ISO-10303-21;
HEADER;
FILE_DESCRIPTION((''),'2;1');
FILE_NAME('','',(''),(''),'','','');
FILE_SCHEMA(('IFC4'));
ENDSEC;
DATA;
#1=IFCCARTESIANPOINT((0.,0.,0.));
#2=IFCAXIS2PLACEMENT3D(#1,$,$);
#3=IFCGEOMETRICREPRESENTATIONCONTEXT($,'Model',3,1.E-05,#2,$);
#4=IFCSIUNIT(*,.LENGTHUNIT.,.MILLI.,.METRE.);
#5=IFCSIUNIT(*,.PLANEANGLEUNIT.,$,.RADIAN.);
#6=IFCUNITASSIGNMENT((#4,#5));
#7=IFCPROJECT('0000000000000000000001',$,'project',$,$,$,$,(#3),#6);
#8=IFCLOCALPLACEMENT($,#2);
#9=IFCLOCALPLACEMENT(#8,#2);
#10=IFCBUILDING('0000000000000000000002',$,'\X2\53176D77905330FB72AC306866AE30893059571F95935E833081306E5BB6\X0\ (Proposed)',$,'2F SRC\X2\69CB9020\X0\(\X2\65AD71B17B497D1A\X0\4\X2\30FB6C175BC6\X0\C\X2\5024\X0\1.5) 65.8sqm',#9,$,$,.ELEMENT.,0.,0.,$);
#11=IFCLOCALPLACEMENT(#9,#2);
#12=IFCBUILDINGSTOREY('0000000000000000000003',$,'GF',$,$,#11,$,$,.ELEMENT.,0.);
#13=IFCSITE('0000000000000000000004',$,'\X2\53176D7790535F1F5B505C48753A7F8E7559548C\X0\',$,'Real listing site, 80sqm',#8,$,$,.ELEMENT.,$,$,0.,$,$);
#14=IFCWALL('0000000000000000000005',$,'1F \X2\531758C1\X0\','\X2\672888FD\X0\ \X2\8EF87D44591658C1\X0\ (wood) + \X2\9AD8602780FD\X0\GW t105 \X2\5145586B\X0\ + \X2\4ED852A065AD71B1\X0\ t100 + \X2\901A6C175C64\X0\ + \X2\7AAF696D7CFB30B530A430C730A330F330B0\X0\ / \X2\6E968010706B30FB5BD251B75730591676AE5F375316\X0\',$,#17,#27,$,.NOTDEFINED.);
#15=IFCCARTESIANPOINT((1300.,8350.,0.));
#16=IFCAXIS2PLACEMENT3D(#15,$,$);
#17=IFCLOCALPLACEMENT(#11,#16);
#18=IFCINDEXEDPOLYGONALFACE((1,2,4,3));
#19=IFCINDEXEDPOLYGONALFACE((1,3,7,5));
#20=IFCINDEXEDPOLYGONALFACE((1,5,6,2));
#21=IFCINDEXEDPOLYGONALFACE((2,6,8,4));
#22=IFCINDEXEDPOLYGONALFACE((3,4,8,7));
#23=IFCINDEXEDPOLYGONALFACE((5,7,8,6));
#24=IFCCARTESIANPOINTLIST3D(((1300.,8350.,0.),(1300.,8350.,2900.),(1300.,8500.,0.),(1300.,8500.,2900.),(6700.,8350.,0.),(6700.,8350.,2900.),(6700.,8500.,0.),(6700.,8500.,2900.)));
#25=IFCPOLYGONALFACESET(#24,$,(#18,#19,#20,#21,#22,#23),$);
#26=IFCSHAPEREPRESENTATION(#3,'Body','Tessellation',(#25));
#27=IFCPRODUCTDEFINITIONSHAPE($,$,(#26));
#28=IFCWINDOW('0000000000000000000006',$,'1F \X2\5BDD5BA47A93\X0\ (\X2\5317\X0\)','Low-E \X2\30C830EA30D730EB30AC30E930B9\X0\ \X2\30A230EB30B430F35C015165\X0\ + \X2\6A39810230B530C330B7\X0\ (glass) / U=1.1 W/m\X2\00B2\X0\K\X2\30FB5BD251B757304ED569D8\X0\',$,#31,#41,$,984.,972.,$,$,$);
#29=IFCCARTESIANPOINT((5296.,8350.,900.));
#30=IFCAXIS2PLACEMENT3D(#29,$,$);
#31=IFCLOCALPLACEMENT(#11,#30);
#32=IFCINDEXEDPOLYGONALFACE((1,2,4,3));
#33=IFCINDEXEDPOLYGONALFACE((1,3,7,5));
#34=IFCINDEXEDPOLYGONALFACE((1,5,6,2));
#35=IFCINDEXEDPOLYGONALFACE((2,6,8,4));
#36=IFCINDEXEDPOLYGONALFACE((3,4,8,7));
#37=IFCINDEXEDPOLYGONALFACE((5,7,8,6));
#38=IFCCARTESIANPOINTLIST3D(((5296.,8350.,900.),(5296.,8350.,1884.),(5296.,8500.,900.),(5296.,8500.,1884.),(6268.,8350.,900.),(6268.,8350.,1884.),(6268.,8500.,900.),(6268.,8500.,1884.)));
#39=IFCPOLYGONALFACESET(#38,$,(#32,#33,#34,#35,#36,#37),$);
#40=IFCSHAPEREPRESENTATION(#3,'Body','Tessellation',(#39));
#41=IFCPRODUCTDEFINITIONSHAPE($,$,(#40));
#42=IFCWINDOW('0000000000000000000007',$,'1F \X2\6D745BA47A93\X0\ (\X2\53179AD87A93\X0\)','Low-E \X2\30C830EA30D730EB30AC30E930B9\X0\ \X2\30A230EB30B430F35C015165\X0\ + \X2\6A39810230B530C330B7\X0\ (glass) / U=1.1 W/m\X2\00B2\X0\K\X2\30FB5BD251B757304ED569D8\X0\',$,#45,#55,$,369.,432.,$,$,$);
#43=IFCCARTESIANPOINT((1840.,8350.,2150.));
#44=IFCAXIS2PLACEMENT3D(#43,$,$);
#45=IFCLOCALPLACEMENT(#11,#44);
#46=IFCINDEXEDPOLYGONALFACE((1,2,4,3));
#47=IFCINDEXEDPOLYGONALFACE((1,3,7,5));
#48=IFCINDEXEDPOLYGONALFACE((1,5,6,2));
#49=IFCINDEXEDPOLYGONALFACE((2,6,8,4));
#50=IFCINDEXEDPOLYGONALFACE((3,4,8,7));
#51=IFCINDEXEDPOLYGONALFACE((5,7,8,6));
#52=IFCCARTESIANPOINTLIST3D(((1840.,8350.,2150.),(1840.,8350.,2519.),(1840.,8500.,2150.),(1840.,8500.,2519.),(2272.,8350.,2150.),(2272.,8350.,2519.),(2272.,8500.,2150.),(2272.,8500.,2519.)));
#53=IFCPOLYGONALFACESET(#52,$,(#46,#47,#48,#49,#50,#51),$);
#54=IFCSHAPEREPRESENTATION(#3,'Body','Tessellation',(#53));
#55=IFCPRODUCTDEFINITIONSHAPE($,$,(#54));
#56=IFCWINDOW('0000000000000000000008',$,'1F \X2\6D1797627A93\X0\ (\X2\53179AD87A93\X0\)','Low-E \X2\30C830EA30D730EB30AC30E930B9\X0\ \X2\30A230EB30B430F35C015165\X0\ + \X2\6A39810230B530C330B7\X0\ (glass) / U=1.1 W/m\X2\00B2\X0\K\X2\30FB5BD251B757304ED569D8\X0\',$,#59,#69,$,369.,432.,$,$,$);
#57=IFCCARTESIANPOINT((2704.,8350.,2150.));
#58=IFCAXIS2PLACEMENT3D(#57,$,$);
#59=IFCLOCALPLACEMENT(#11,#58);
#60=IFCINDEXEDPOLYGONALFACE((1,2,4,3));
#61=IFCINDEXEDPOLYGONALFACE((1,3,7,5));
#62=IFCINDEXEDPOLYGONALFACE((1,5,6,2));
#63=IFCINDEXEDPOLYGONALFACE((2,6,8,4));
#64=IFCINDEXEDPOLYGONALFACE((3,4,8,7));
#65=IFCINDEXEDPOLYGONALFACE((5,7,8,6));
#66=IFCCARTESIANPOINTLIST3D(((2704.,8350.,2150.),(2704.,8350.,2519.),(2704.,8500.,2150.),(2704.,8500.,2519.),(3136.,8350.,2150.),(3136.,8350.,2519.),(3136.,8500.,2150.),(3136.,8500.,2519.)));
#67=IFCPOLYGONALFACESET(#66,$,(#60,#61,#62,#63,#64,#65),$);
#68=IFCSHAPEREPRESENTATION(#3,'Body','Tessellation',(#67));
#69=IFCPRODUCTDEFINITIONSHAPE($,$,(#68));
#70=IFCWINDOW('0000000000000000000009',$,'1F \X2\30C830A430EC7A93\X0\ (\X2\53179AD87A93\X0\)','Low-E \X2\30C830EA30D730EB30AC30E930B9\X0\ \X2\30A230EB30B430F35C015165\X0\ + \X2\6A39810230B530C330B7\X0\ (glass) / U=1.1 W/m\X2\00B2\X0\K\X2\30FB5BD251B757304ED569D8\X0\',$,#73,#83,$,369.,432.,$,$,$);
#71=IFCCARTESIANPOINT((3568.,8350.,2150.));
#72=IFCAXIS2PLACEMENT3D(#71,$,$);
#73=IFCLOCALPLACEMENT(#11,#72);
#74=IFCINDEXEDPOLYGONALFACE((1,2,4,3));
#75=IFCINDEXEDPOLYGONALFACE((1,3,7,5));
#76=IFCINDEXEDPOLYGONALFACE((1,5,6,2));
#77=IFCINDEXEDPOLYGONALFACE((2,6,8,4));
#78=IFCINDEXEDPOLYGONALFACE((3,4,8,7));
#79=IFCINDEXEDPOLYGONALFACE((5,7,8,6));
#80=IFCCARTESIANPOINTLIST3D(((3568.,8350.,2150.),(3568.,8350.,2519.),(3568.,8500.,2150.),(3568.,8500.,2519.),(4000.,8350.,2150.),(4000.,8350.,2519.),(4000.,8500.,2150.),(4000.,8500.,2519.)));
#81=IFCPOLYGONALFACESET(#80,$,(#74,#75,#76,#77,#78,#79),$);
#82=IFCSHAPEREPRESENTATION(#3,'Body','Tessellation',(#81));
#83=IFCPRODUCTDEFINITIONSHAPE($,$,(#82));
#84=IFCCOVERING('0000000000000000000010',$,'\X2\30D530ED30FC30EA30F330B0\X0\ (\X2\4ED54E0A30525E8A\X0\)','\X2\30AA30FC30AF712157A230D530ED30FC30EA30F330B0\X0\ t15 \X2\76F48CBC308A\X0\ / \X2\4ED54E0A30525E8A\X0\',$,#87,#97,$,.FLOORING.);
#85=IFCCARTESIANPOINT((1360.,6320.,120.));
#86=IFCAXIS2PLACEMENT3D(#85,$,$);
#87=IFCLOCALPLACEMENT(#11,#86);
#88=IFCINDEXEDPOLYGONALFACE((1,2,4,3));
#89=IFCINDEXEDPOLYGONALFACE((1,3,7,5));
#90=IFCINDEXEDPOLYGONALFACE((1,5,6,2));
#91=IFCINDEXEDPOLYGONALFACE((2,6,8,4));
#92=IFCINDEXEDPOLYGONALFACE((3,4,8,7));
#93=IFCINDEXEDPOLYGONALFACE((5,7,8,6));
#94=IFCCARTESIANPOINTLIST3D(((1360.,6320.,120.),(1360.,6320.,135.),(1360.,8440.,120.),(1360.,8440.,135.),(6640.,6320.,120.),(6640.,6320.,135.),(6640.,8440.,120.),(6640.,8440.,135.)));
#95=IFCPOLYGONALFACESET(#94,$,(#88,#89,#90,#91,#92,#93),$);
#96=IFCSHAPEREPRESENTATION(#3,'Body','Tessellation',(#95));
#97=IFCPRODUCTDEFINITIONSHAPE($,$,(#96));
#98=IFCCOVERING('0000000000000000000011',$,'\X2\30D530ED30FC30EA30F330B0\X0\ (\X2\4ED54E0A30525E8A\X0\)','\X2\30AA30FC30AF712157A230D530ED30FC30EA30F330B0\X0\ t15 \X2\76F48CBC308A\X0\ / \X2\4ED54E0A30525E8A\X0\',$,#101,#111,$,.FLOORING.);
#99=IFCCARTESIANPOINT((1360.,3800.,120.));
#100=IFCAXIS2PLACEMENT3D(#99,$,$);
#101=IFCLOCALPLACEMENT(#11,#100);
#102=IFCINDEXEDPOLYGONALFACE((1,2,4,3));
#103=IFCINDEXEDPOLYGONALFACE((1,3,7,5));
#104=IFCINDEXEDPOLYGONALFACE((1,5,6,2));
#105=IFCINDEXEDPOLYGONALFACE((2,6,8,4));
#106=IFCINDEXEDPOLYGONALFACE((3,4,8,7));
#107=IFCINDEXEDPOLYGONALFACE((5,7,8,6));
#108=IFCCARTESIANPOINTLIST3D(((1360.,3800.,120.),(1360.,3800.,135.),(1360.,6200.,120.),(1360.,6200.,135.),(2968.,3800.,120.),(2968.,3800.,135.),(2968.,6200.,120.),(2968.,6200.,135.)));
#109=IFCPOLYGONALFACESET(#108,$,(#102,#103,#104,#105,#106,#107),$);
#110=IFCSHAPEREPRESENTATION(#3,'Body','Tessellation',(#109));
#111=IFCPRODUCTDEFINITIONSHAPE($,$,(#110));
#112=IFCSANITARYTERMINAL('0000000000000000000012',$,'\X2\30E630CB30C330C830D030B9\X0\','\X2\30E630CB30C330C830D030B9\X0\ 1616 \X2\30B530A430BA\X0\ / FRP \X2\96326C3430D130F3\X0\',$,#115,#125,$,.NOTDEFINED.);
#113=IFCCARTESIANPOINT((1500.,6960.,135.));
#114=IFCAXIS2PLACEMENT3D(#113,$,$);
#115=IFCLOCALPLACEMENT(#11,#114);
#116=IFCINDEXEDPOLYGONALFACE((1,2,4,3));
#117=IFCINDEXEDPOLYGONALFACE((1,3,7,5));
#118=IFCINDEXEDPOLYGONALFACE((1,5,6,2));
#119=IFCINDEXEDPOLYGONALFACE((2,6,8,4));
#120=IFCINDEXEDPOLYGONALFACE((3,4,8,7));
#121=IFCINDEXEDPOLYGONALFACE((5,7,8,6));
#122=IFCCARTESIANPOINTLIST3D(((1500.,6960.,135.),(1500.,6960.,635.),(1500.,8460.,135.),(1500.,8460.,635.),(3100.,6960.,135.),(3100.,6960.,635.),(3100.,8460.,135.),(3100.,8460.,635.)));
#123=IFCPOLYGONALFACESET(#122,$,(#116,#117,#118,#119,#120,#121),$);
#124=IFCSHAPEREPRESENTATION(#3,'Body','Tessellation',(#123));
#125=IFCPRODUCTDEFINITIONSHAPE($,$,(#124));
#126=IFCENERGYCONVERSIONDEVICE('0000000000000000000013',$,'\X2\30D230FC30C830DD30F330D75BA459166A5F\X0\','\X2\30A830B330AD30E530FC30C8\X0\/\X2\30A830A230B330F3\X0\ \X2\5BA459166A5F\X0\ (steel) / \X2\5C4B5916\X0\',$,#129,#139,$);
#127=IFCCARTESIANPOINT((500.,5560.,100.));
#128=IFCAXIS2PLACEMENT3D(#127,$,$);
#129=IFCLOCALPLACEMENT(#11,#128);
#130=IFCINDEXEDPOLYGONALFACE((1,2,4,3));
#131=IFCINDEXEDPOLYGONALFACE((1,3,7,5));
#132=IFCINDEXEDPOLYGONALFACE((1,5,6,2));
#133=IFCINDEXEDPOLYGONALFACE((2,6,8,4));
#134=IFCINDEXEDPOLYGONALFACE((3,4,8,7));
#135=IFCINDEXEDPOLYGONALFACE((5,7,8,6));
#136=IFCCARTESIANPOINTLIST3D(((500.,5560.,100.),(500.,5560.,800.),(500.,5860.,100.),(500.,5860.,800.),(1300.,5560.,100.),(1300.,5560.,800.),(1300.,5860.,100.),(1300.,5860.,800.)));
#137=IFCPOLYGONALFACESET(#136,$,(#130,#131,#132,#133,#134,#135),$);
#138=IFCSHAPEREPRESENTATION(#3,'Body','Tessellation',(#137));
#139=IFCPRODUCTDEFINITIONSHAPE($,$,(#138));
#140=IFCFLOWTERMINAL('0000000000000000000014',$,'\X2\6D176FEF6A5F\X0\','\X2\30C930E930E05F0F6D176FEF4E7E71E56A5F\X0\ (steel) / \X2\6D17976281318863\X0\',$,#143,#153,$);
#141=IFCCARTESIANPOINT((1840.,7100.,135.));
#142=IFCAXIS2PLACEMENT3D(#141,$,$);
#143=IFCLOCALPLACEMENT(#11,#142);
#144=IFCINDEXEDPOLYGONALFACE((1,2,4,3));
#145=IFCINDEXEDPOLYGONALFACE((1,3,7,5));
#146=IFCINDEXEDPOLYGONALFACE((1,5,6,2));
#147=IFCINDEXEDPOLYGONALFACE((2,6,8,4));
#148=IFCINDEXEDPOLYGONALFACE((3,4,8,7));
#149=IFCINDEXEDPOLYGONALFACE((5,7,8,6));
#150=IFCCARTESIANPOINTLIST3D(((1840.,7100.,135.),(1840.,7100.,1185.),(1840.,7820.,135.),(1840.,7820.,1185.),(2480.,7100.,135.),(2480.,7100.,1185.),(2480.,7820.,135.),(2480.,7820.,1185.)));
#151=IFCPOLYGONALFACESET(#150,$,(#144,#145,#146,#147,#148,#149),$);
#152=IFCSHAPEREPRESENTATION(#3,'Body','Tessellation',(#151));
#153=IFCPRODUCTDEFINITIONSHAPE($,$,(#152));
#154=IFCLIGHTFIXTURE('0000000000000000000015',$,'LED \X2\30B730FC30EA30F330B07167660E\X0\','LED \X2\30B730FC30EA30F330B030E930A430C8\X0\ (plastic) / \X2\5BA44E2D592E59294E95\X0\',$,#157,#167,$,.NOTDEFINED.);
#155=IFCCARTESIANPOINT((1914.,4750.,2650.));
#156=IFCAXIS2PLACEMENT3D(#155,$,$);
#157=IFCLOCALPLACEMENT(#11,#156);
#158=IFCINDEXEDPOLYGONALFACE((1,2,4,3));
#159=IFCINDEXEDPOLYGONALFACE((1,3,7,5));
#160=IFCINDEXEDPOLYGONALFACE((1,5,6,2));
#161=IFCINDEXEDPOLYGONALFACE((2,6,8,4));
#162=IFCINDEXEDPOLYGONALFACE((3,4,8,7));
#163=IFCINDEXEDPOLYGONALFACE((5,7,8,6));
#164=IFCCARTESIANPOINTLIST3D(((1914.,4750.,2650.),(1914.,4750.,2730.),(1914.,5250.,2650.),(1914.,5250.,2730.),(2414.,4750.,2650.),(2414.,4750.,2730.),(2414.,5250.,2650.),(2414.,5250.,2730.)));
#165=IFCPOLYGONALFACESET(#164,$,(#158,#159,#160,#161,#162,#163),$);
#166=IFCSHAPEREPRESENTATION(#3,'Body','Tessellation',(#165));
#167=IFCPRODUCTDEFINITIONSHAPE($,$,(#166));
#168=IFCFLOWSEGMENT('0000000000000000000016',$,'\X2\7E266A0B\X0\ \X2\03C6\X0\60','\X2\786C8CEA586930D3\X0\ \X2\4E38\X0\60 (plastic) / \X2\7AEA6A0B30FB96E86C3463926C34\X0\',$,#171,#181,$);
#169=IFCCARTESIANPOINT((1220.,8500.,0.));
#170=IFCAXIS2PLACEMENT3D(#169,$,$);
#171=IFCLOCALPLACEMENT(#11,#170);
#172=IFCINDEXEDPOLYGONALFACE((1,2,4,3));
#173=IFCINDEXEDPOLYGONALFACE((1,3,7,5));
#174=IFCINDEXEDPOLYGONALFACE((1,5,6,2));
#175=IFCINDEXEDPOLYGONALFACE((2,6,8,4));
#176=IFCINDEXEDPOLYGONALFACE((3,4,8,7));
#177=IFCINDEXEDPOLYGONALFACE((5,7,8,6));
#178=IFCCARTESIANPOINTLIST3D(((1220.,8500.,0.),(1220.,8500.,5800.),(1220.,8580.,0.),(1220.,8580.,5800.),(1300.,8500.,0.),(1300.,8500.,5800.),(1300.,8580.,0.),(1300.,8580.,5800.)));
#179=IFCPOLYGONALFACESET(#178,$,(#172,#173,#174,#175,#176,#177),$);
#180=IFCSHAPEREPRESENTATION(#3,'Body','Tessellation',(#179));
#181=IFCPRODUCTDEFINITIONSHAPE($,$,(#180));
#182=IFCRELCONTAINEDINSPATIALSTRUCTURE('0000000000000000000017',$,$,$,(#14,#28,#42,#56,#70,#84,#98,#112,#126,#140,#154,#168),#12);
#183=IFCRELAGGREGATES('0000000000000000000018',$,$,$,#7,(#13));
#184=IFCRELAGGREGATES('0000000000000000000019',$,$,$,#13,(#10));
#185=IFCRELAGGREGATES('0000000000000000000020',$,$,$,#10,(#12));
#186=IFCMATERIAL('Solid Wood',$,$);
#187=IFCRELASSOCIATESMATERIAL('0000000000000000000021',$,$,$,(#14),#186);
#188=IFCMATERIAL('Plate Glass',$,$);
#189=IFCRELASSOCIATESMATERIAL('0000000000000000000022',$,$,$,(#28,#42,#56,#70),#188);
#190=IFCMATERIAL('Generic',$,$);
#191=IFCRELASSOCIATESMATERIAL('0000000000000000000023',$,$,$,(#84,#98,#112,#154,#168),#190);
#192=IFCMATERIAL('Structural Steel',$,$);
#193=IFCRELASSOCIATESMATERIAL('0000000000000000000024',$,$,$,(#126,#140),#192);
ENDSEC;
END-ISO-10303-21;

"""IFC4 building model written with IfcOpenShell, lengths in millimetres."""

from ifc_helpers import new_model, si_unit, frame, frame_2d, origin, place, context, project, spatial, rectangle, extrude, material, element, fill, save


model = new_model("IFC4")

# Units and contexts
model_context = context("Model", 3, precision=1e-05, world=origin())
ifc_project = project(units=[si_unit("LENGTHUNIT", "METRE", prefix="MILLI"), si_unit("PLANEANGLEUNIT", "RADIAN")], contexts=[model_context])

# Site, building, storey
site_placement = place(None, origin())
site = spatial("IfcSite", under=ifc_project, at=site_placement, Name="北海道弟子屈町美留和", ObjectType="Real listing site, 80sqm", CompositionType="ELEMENT", RefElevation=0.0)
building_placement = place(site_placement, origin())
building = spatial("IfcBuilding", under=site, at=building_placement, Name="北海道・犬と暮らす土間広めの家 (Proposed)", ObjectType="2F SRC構造(断熱等級4・気密C値1.5) 65.8sqm", CompositionType="ELEMENT", ElevationOfRefHeight=0.0, ElevationOfTerrain=0.0)
storey_placement = place(building_placement, origin())
storey = spatial("IfcBuildingStorey", under=building, at=storey_placement, Name="GF", CompositionType="ELEMENT", Elevation=0.0)

# Shared definitions
ifc_material_1 = material(Name="Solid Wood")

# Wall, openings, windows
wall_1_placement = place(storey_placement, frame((1300.0, 8350.0, 0.0)))
wall_1 = element("IfcWall", 1, at=wall_1_placement, inside=storey, material=ifc_material_1, Name="1F 北壁", Description="木製 軸組外壁 (wood) + 高性能GW t105 充填 + 付加断熱 t100 + 通気層 + 窯業系サイディング / 準耐火・寒冷地外皮強化", PredefinedType="NOTDEFINED", context=model_context, shape_type="SweptSolid", body=[
    extrude(rectangle(XDim=5400.0, YDim=150.0, at=frame_2d((2700.0, 75.0))), frame((1300.0, 8350.0, 0.0)), (0.0, 0.0, 1.0), 2900.0),
])
opening_1_placement = place(storey_placement, frame((5296.0, 8350.0, 900.0)))
opening_1 = element("IfcOpeningElement", 2, at=opening_1_placement, cuts=wall_1, PredefinedType="NOTDEFINED", context=model_context, shape_type="SweptSolid", body=[
    extrude(rectangle(XDim=972.0, YDim=150.0, at=frame_2d((486.0, 75.0))), frame((5296.0, 8350.0, 900.0)), (0.0, 0.0, 1.0), 984.0),
])
opening_2_placement = place(storey_placement, frame((1840.0, 8350.0, 2150.0)))
opening_2 = element("IfcOpeningElement", 3, at=opening_2_placement, cuts=wall_1, PredefinedType="NOTDEFINED", context=model_context, shape_type="SweptSolid", body=[
    extrude(rectangle(XDim=432.0, YDim=150.0, at=frame_2d((216.0, 75.0))), frame((1840.0, 8350.0, 2150.0)), (0.0, 0.0, 1.0), 369.0),
])
opening_3_placement = place(storey_placement, frame((2704.0, 8350.0, 2150.0)))
opening_3 = element("IfcOpeningElement", 4, at=opening_3_placement, cuts=wall_1, PredefinedType="NOTDEFINED", context=model_context, shape_type="SweptSolid", body=[
    extrude(rectangle(XDim=432.0, YDim=150.0, at=frame_2d((216.0, 75.0))), frame((2704.0, 8350.0, 2150.0)), (0.0, 0.0, 1.0), 369.0),
])
opening_4_placement = place(storey_placement, frame((3568.0, 8350.0, 2150.0)))
opening_4 = element("IfcOpeningElement", 5, at=opening_4_placement, cuts=wall_1, PredefinedType="NOTDEFINED", context=model_context, shape_type="SweptSolid", body=[
    extrude(rectangle(XDim=432.0, YDim=150.0, at=frame_2d((216.0, 75.0))), frame((3568.0, 8350.0, 2150.0)), (0.0, 0.0, 1.0), 369.0),
])
ifc_material_2 = material(Name="Plate Glass")
window_1_placement = place(storey_placement, frame((5296.0, 8350.0, 900.0)))
window_1 = element("IfcWindow", 6, at=window_1_placement, inside=storey, material=ifc_material_2, Name="1F 寝室窓 (北)", Description="Low-E トリプルガラス アルゴン封入 + 樹脂サッシ (glass) / U=1.1 W/m²K・寒冷地仕様", OverallHeight=984.0, OverallWidth=972.0, context=model_context, shape_type="SweptSolid", body=[
    extrude(rectangle(XDim=972.0, YDim=150.0, at=frame_2d((486.0, 75.0))), frame((5296.0, 8350.0, 900.0)), (0.0, 0.0, 1.0), 984.0),
])
fill(opening_1, window_1)
window_2_placement = place(storey_placement, frame((1840.0, 8350.0, 2150.0)))
window_2 = element("IfcWindow", 7, at=window_2_placement, inside=storey, material=ifc_material_2, Name="1F 浴室窓 (北高窓)", Description="Low-E トリプルガラス アルゴン封入 + 樹脂サッシ (glass) / U=1.1 W/m²K・寒冷地仕様", OverallHeight=369.0, OverallWidth=432.0, context=model_context, shape_type="SweptSolid", body=[
    extrude(rectangle(XDim=432.0, YDim=150.0, at=frame_2d((216.0, 75.0))), frame((1840.0, 8350.0, 2150.0)), (0.0, 0.0, 1.0), 369.0),
])
fill(opening_2, window_2)
window_3_placement = place(storey_placement, frame((2704.0, 8350.0, 2150.0)))
window_3 = element("IfcWindow", 8, at=window_3_placement, inside=storey, material=ifc_material_2, Name="1F 洗面窓 (北高窓)", Description="Low-E トリプルガラス アルゴン封入 + 樹脂サッシ (glass) / U=1.1 W/m²K・寒冷地仕様", OverallHeight=369.0, OverallWidth=432.0, context=model_context, shape_type="SweptSolid", body=[
    extrude(rectangle(XDim=432.0, YDim=150.0, at=frame_2d((216.0, 75.0))), frame((2704.0, 8350.0, 2150.0)), (0.0, 0.0, 1.0), 369.0),
])
fill(opening_3, window_3)
window_4_placement = place(storey_placement, frame((3568.0, 8350.0, 2150.0)))
window_4 = element("IfcWindow", 9, at=window_4_placement, inside=storey, material=ifc_material_2, Name="1F トイレ窓 (北高窓)", Description="Low-E トリプルガラス アルゴン封入 + 樹脂サッシ (glass) / U=1.1 W/m²K・寒冷地仕様", OverallHeight=369.0, OverallWidth=432.0, context=model_context, shape_type="SweptSolid", body=[
    extrude(rectangle(XDim=432.0, YDim=150.0, at=frame_2d((216.0, 75.0))), frame((3568.0, 8350.0, 2150.0)), (0.0, 0.0, 1.0), 369.0),
])
fill(opening_4, window_4)

# Coverings
ifc_material_3 = material(Name="Generic")
covering_1_placement = place(storey_placement, frame((1360.0, 6320.0, 120.0)))
element("IfcCovering", 10, at=covering_1_placement, inside=storey, material=ifc_material_3, Name="フローリング (仕上げ床)", Description="オーク無垢フローリング t15 直貼り / 仕上げ床", PredefinedType="FLOORING", context=model_context, shape_type="SweptSolid", body=[
    extrude(rectangle(XDim=5280.0, YDim=2120.0, at=frame_2d((2640.0, 1060.0))), frame((1360.0, 6320.0, 120.0)), (0.0, 0.0, 1.0), 15.0),
])
covering_2_placement = place(storey_placement, frame((1360.0, 3800.0, 120.0)))
element("IfcCovering", 11, at=covering_2_placement, inside=storey, material=ifc_material_3, Name="フローリング (仕上げ床)", Description="オーク無垢フローリング t15 直貼り / 仕上げ床", PredefinedType="FLOORING", context=model_context, shape_type="SweptSolid", body=[
    extrude(rectangle(XDim=1608.0, YDim=2400.0, at=frame_2d((804.0, 1200.0))), frame((1360.0, 3800.0, 120.0)), (0.0, 0.0, 1.0), 15.0),
])

# Sanitary terminal
sanitary_terminal_placement = place(storey_placement, frame((1500.0, 6960.0, 135.0)))
element("IfcSanitaryTerminal", 12, at=sanitary_terminal_placement, inside=storey, material=ifc_material_3, Name="ユニットバス", Description="ユニットバス 1616 サイズ / FRP 防水パン", PredefinedType="NOTDEFINED", context=model_context, shape_type="SweptSolid", body=[
    extrude(rectangle(XDim=1600.0, YDim=1500.0, at=frame_2d((800.0, 750.0))), frame((1500.0, 6960.0, 135.0)), (0.0, 0.0, 1.0), 500.0),
])

# Shared definitions
ifc_material_4 = material(Name="Structural Steel")

# Energy conversion device
energy_conversion_device_placement = place(storey_placement, frame((500.0, 5560.0, 100.0)))
element("IfcEnergyConversionDevice", 13, at=energy_conversion_device_placement, inside=storey, material=ifc_material_4, Name="ヒートポンプ室外機", Description="エコキュート/エアコン 室外機 (steel) / 屋外", context=model_context, shape_type="SweptSolid", body=[
    extrude(rectangle(XDim=800.0, YDim=300.0, at=frame_2d((400.0, 150.0))), frame((500.0, 5560.0, 100.0)), (0.0, 0.0, 1.0), 700.0),
])

# Flow terminal
flow_terminal_placement = place(storey_placement, frame((1840.0, 7100.0, 135.0)))
element("IfcFlowTerminal", 14, at=flow_terminal_placement, inside=storey, material=ifc_material_4, Name="洗濯機", Description="ドラム式洗濯乾燥機 (steel) / 洗面脱衣", context=model_context, shape_type="SweptSolid", body=[
    extrude(rectangle(XDim=640.0, YDim=720.0, at=frame_2d((320.0, 360.0))), frame((1840.0, 7100.0, 135.0)), (0.0, 0.0, 1.0), 1050.0),
])

# Light fixture
light_fixture_placement = place(storey_placement, frame((1914.0, 4750.0, 2650.0)))
element("IfcLightFixture", 15, at=light_fixture_placement, inside=storey, material=ifc_material_3, Name="LED シーリング照明", Description="LED シーリングライト (plastic) / 室中央天井", PredefinedType="NOTDEFINED", context=model_context, shape_type="SweptSolid", body=[
    extrude(rectangle(XDim=500.0, YDim=500.0, at=frame_2d((250.0, 250.0))), frame((1914.0, 4750.0, 2650.0)), (0.0, 0.0, 1.0), 80.0),
])

# Flow segment
flow_segment_placement = place(storey_placement, frame((1220.0, 8500.0, 0.0)))
element("IfcFlowSegment", 16, at=flow_segment_placement, inside=storey, material=ifc_material_3, Name="縦樋 φ60", Description="硬質塩ビ 丸60 (plastic) / 竪樋・雨水排水", context=model_context, shape_type="SweptSolid", body=[
    extrude(rectangle(XDim=80.0, YDim=80.0, at=frame_2d((40.0, 40.0))), frame((1220.0, 8500.0, 0.0)), (0.0, 0.0, 1.0), 5800.0),
])

save(model, "model.ifc")
